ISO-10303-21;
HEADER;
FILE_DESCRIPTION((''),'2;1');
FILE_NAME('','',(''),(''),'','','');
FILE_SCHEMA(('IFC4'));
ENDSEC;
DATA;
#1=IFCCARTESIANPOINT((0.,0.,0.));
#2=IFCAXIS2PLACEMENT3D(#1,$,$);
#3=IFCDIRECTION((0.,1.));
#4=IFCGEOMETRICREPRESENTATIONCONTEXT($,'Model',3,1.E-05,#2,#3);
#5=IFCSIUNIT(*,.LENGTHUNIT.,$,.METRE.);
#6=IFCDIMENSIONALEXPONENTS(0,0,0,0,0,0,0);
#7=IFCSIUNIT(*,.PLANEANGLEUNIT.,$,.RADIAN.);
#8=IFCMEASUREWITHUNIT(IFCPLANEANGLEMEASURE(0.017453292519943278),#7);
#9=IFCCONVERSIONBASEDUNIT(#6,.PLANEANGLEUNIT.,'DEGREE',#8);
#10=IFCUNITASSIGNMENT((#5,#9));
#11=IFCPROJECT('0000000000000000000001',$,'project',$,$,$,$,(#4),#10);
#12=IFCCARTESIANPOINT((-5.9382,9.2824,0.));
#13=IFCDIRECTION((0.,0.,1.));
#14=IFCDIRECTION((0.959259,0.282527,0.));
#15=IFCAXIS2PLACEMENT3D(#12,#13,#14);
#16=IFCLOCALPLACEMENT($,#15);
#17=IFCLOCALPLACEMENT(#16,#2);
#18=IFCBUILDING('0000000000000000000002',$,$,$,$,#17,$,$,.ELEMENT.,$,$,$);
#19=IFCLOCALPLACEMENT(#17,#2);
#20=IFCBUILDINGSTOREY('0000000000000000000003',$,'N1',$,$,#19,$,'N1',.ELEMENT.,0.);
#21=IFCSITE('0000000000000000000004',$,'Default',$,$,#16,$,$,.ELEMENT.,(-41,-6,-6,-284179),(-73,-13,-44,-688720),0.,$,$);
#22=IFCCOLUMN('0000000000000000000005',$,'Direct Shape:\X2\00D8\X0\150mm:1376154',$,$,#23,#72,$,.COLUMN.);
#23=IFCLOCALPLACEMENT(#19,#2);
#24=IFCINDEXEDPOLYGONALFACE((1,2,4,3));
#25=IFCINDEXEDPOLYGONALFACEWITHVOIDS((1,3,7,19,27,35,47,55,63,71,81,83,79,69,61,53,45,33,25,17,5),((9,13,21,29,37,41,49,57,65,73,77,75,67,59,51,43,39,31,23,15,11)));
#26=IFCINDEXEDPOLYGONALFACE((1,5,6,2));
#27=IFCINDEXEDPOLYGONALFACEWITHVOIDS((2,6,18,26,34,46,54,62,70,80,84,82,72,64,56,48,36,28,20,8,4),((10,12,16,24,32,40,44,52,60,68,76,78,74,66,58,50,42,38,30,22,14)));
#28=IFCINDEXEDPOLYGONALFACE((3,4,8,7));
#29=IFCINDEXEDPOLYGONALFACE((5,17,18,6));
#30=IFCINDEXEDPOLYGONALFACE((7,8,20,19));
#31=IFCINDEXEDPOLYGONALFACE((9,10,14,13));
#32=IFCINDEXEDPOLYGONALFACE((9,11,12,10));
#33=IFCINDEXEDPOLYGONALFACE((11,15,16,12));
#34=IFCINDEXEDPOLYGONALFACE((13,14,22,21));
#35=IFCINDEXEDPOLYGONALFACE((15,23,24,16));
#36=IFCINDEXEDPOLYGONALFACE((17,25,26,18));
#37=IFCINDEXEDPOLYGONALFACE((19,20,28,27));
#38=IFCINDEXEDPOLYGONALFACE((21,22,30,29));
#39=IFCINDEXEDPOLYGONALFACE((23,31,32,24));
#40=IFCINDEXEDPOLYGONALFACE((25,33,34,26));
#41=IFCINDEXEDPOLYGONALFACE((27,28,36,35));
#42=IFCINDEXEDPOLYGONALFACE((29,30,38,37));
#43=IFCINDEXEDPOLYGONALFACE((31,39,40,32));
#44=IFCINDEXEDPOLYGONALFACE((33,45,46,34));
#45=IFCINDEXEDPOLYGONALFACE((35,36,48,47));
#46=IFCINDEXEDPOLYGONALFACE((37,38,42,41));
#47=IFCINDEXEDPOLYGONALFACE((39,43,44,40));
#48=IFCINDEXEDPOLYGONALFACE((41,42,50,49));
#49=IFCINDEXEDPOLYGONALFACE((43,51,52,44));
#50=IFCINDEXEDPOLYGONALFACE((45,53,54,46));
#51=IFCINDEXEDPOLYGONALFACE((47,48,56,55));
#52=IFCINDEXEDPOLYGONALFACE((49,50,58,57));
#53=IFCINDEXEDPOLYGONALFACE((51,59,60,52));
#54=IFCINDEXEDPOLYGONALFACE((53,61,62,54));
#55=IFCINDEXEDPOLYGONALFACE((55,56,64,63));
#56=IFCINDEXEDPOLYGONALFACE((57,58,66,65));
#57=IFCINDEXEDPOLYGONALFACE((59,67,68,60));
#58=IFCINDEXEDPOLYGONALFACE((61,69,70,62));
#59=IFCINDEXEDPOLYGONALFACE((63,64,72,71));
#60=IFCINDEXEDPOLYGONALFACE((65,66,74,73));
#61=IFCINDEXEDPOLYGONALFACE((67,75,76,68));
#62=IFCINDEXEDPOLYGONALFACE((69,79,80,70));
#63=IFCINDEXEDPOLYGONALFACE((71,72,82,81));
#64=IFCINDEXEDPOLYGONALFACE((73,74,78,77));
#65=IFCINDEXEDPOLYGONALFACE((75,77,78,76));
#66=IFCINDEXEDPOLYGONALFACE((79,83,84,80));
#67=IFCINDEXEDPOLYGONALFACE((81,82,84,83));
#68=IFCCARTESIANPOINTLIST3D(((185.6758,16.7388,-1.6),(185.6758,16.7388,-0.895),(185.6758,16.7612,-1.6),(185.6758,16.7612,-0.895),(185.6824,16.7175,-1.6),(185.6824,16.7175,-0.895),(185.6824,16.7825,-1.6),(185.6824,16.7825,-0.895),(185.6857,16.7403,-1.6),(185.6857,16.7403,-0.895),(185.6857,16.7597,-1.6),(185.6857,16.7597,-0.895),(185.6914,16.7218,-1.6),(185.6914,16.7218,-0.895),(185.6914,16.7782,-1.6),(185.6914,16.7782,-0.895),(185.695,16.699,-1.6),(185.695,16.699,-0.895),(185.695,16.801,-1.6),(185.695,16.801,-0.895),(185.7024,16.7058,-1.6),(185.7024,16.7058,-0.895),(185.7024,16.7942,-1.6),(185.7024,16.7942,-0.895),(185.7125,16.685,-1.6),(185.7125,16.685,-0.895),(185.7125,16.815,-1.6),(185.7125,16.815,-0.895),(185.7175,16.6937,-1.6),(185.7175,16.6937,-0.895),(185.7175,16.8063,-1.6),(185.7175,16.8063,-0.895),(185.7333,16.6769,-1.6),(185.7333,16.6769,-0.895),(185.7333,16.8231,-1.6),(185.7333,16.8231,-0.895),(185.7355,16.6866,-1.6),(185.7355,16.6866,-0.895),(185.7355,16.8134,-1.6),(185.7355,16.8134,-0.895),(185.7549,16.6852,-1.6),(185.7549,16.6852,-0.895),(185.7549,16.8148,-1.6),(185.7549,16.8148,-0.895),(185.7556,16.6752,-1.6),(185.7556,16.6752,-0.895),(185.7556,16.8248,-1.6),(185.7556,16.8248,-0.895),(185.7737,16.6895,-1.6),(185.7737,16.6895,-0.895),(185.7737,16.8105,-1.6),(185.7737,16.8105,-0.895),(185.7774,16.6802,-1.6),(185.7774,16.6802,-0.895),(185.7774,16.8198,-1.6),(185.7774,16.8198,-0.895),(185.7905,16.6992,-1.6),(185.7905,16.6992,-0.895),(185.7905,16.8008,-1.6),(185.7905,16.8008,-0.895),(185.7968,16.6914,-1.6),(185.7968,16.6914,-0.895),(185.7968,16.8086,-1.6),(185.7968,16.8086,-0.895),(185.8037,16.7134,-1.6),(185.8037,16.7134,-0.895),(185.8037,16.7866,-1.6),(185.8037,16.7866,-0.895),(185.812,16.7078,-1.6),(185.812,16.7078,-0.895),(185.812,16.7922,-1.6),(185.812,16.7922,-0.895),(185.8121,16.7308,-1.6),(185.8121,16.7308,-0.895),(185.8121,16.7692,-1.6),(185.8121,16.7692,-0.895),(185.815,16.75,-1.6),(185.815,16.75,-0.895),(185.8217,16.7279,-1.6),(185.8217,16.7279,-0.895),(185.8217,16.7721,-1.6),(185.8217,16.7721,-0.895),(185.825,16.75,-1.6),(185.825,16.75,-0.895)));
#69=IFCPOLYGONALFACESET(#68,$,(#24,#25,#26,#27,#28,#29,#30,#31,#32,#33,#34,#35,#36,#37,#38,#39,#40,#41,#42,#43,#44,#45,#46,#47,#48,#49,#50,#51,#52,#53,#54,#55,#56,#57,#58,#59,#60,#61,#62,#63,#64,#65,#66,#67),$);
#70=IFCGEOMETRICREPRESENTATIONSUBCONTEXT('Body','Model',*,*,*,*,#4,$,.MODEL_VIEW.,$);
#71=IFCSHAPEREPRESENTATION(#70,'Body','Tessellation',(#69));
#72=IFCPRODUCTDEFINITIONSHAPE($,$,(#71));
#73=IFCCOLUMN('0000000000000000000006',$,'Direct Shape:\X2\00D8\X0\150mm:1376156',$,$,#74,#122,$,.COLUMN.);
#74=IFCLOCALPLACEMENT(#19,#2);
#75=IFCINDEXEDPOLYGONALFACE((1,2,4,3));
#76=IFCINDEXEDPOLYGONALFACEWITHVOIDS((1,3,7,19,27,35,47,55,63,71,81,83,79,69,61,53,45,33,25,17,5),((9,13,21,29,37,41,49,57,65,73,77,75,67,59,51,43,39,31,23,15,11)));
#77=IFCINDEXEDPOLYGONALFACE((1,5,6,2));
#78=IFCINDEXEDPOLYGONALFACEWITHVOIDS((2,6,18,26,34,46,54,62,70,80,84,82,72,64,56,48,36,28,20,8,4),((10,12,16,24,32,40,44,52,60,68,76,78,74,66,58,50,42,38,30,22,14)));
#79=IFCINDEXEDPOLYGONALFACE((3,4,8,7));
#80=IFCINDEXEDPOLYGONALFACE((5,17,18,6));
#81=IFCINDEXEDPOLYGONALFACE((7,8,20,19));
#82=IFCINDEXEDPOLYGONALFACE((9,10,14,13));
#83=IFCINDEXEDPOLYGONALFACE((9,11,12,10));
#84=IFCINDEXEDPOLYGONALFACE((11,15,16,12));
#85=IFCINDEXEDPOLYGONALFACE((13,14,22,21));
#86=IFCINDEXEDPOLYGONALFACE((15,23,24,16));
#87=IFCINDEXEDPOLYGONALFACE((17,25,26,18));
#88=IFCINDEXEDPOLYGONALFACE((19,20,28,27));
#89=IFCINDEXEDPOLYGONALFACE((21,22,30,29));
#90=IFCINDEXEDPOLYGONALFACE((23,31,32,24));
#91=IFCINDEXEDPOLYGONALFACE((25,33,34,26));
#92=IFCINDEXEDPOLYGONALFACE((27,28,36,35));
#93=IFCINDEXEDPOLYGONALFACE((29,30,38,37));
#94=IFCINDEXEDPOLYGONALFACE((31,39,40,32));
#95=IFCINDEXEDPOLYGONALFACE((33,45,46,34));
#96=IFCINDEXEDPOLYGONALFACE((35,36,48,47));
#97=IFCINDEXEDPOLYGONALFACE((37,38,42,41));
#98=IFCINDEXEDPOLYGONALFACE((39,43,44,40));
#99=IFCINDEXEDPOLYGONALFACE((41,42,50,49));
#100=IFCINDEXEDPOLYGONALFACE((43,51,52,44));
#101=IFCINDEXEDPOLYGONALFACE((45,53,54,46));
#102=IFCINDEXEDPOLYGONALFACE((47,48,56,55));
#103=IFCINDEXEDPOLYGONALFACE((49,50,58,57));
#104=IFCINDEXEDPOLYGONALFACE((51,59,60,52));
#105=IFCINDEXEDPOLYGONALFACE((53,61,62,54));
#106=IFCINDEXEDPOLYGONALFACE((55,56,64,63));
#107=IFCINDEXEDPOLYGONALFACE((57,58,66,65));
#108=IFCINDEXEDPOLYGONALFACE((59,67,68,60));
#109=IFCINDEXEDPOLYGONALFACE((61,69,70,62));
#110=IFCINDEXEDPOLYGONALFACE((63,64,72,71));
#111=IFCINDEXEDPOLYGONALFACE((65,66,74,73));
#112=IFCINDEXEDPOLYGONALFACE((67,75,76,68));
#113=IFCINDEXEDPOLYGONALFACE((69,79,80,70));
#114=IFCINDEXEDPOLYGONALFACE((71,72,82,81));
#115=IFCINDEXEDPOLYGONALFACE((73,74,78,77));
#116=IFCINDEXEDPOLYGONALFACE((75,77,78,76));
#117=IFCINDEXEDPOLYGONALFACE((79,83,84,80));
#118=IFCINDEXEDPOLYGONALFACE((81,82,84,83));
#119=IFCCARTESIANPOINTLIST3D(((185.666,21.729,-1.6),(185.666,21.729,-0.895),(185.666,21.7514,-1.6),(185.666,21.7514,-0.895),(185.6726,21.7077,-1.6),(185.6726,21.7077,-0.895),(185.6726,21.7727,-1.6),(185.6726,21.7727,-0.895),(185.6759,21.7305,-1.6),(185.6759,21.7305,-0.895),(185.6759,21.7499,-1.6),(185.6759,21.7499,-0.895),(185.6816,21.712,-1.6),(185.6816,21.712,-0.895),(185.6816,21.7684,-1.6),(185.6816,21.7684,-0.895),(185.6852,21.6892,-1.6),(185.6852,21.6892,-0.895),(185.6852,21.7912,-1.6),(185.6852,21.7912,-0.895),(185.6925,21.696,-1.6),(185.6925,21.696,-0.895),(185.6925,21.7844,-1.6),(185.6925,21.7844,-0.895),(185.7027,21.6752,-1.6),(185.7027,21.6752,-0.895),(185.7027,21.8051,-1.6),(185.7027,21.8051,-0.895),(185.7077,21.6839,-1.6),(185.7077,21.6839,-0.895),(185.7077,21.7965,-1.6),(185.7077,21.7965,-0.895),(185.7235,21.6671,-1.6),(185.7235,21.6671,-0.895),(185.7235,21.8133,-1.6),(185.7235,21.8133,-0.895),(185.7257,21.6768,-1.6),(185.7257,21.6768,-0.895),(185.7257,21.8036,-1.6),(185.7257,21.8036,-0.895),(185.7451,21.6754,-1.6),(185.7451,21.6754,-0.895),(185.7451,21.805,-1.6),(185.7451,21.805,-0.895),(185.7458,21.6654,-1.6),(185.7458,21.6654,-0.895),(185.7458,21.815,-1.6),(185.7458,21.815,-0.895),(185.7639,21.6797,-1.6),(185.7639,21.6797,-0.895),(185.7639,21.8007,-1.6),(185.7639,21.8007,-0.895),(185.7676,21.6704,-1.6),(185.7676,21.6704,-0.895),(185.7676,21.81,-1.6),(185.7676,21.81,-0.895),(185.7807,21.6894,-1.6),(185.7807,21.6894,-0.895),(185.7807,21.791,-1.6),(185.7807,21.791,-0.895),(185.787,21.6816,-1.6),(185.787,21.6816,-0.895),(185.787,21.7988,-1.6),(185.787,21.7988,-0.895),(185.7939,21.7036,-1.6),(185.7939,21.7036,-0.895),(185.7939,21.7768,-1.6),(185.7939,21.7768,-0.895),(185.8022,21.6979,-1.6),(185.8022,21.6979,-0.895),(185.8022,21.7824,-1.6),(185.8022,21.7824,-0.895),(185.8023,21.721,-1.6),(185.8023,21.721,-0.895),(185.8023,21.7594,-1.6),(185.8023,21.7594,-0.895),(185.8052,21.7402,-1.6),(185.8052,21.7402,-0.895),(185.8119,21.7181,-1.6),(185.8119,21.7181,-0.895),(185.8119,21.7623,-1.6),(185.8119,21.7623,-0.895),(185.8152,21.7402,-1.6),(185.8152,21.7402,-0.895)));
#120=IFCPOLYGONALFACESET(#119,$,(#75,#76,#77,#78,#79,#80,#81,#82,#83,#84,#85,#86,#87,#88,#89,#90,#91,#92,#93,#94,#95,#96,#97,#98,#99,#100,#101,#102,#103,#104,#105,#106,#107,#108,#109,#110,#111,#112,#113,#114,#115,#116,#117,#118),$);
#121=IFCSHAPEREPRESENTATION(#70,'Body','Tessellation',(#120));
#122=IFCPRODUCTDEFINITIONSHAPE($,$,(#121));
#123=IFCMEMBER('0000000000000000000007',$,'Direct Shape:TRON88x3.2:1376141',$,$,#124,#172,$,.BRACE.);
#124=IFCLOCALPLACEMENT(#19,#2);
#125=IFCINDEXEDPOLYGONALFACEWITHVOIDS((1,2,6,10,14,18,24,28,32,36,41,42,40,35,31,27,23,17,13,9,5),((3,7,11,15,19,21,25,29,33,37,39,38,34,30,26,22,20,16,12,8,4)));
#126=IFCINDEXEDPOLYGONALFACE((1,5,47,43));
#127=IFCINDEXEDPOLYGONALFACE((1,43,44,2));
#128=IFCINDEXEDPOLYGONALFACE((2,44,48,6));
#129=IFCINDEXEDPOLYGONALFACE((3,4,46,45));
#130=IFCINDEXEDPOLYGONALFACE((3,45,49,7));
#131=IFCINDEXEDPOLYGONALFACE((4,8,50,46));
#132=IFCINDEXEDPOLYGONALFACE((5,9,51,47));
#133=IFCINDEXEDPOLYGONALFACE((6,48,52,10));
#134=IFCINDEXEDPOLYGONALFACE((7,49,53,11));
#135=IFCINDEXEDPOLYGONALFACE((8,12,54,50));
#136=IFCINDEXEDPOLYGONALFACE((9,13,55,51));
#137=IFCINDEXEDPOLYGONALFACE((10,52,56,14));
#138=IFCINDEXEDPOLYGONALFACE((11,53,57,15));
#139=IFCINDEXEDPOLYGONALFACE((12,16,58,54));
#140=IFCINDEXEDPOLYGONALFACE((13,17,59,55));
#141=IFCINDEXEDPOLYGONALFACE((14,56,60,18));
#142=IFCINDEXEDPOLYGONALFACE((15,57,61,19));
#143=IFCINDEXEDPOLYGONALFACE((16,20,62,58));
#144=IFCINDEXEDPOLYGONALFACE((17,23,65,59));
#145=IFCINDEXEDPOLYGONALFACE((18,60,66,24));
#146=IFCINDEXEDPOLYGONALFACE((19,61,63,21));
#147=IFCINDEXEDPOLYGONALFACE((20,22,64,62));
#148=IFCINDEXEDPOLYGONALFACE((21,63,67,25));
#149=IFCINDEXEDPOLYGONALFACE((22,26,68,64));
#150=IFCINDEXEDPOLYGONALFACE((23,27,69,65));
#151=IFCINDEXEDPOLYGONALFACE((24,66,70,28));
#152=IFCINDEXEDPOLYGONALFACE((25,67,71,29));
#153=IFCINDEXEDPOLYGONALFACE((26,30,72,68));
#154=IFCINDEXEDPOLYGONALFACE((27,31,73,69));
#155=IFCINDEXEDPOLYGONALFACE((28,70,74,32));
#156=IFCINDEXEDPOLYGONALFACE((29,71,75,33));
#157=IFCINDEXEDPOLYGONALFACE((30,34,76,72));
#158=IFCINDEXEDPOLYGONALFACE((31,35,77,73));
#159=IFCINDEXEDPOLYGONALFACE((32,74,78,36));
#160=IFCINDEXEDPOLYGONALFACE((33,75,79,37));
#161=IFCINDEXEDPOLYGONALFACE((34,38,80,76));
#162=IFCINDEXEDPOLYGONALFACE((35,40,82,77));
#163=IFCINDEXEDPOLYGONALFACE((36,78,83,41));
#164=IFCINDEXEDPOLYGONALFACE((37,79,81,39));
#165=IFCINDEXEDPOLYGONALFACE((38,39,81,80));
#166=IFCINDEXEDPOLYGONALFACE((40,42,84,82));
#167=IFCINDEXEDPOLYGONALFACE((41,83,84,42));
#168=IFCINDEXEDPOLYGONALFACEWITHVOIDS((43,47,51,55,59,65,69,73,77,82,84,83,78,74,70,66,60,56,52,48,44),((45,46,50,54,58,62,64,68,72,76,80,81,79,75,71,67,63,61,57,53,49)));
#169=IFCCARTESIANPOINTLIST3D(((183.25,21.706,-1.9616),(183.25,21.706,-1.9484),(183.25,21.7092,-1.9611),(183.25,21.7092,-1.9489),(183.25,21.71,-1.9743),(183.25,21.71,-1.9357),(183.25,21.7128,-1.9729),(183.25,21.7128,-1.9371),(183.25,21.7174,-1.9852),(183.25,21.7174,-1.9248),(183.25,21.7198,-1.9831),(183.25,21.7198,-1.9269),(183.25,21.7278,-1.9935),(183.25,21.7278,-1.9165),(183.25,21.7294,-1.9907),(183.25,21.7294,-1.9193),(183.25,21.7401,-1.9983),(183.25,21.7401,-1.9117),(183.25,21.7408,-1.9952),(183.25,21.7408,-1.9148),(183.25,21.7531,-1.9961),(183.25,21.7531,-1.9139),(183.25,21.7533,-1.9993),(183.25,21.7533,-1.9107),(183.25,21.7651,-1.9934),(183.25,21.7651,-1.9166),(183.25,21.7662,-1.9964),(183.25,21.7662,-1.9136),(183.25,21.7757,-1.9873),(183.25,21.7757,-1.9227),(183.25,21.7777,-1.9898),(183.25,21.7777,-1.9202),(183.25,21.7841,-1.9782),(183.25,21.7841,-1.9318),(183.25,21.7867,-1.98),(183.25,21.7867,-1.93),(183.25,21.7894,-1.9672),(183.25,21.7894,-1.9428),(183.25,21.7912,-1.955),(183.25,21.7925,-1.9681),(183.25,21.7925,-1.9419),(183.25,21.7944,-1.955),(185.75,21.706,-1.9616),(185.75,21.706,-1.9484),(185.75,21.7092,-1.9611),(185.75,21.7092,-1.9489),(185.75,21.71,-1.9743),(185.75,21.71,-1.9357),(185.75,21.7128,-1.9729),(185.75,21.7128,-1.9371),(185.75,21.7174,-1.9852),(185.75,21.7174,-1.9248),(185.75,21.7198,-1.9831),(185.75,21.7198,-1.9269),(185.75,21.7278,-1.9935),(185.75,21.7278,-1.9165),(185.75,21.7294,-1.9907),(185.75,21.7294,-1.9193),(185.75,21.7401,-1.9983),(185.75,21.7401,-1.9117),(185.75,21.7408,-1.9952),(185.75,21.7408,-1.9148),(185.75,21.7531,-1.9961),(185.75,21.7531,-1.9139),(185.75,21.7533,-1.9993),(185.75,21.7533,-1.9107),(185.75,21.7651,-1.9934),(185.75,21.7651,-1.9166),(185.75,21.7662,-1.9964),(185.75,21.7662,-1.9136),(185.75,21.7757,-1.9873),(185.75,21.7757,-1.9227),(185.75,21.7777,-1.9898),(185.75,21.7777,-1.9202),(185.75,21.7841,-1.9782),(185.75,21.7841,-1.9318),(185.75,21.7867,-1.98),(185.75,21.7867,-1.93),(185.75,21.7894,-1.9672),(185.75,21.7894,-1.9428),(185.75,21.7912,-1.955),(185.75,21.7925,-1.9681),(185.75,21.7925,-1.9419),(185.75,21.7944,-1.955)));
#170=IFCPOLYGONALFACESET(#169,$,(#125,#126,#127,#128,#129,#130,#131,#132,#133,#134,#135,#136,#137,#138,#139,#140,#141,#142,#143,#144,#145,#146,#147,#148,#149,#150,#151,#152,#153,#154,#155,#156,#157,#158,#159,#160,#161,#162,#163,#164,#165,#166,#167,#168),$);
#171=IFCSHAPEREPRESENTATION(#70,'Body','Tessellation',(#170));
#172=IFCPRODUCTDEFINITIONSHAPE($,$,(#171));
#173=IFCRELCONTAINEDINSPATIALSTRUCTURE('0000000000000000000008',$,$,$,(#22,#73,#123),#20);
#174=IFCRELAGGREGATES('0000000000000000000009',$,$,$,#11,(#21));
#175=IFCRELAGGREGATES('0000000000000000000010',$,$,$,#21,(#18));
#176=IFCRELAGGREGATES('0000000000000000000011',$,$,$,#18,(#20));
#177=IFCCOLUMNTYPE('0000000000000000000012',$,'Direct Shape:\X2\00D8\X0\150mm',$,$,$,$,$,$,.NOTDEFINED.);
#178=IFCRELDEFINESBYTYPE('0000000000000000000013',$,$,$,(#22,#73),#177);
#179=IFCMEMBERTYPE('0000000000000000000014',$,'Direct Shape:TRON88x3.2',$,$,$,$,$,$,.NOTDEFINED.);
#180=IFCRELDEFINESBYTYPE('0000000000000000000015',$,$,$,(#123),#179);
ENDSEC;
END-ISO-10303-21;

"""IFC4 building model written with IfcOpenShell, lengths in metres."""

from ifc_helpers import new_model, entity, si_unit, converted_unit, direction, frame, frame_2d, origin, origin_2d_with_axis, place, context, subcontext, project, spatial, hollow_circle, extrude, type_object, element, save


model = new_model("IFC4")

# Units and contexts
model_context = context("Model", 3, precision=1e-05, world=origin(), true_north=direction((0.0, 1.0)))
body_context = subcontext(model_context, "Body", "Model", "MODEL_VIEW")
ifc_project = project(units=[si_unit("LENGTHUNIT", "METRE"), converted_unit("PLANEANGLEUNIT", "DEGREE", entity("IfcPlaneAngleMeasure", 0.017453292519943278), si_unit("PLANEANGLEUNIT", "RADIAN"), dimensions=[0, 0, 0, 0, 0, 0, 0])], contexts=[model_context])

# Site, building, storey
site_placement = place(None, frame((-5.9382, 9.2824, 0.0), z_axis=(0.0, 0.0, 1.0), x_axis=(0.959259, 0.282527, 0.0)))
site = spatial("IfcSite", under=ifc_project, at=site_placement, Name="Default", CompositionType="ELEMENT", RefLatitude=(-41, -6, -6, -284179), RefLongitude=(-73, -13, -44, -688720), RefElevation=0.0)
building_placement = place(site_placement, origin())
building = spatial("IfcBuilding", under=site, at=building_placement, CompositionType="ELEMENT")
storey_placement = place(building_placement, origin())
storey = spatial("IfcBuildingStorey", under=building, at=storey_placement, Name="N1", LongName="N1", CompositionType="ELEMENT", Elevation=0.0)

# Columns
column_type = type_object("IfcColumnType", Name="Direct Shape:Ø150mm", PredefinedType="NOTDEFINED")
column_1_placement = place(storey_placement, origin())
element("IfcColumn", 1, at=column_1_placement, inside=storey, type_object=column_type, Name="Direct Shape:Ø150mm:1376154", PredefinedType="COLUMN", context=body_context, shape_type="SweptSolid", body=[
    extrude(hollow_circle(Radius=0.075, WallThickness=0.01, at=origin_2d_with_axis()), frame((185.75, 16.75, -1.6)), (0.0, 0.0, 1.0), 0.705),
])
column_2_placement = place(storey_placement, origin())
element("IfcColumn", 2, at=column_2_placement, inside=storey, type_object=column_type, Name="Direct Shape:Ø150mm:1376156", PredefinedType="COLUMN", context=body_context, shape_type="SweptSolid", body=[
    extrude(hollow_circle(Radius=0.075, WallThickness=0.01, at=origin_2d_with_axis()), frame((185.7402, 21.7402, -1.6)), (0.0, 0.0, 1.0), 0.705),
])

# Member
member_type_1 = type_object("IfcMemberType", Name="Direct Shape:TRON88x3.2", PredefinedType="NOTDEFINED")
member_1_placement = place(storey_placement, origin())
element("IfcMember", 3, at=member_1_placement, inside=storey, type_object=member_type_1, Name="Direct Shape:TRON88x3.2:1376141", PredefinedType="BRACE", context=body_context, shape_type="SweptSolid", body=[
    extrude(hollow_circle(Radius=0.0445, WallThickness=0.0032, at=frame_2d((0.0, 0.0), x_axis=(1.0, 0.0))), frame((183.25, 21.75, -1.955), z_axis=(1.0, 0.0, 0.0), x_axis=(0.0, 1.0, 0.0)), (0.0, 0.0, 1.0), 2.5),
])

save(model, "model.ifc")
